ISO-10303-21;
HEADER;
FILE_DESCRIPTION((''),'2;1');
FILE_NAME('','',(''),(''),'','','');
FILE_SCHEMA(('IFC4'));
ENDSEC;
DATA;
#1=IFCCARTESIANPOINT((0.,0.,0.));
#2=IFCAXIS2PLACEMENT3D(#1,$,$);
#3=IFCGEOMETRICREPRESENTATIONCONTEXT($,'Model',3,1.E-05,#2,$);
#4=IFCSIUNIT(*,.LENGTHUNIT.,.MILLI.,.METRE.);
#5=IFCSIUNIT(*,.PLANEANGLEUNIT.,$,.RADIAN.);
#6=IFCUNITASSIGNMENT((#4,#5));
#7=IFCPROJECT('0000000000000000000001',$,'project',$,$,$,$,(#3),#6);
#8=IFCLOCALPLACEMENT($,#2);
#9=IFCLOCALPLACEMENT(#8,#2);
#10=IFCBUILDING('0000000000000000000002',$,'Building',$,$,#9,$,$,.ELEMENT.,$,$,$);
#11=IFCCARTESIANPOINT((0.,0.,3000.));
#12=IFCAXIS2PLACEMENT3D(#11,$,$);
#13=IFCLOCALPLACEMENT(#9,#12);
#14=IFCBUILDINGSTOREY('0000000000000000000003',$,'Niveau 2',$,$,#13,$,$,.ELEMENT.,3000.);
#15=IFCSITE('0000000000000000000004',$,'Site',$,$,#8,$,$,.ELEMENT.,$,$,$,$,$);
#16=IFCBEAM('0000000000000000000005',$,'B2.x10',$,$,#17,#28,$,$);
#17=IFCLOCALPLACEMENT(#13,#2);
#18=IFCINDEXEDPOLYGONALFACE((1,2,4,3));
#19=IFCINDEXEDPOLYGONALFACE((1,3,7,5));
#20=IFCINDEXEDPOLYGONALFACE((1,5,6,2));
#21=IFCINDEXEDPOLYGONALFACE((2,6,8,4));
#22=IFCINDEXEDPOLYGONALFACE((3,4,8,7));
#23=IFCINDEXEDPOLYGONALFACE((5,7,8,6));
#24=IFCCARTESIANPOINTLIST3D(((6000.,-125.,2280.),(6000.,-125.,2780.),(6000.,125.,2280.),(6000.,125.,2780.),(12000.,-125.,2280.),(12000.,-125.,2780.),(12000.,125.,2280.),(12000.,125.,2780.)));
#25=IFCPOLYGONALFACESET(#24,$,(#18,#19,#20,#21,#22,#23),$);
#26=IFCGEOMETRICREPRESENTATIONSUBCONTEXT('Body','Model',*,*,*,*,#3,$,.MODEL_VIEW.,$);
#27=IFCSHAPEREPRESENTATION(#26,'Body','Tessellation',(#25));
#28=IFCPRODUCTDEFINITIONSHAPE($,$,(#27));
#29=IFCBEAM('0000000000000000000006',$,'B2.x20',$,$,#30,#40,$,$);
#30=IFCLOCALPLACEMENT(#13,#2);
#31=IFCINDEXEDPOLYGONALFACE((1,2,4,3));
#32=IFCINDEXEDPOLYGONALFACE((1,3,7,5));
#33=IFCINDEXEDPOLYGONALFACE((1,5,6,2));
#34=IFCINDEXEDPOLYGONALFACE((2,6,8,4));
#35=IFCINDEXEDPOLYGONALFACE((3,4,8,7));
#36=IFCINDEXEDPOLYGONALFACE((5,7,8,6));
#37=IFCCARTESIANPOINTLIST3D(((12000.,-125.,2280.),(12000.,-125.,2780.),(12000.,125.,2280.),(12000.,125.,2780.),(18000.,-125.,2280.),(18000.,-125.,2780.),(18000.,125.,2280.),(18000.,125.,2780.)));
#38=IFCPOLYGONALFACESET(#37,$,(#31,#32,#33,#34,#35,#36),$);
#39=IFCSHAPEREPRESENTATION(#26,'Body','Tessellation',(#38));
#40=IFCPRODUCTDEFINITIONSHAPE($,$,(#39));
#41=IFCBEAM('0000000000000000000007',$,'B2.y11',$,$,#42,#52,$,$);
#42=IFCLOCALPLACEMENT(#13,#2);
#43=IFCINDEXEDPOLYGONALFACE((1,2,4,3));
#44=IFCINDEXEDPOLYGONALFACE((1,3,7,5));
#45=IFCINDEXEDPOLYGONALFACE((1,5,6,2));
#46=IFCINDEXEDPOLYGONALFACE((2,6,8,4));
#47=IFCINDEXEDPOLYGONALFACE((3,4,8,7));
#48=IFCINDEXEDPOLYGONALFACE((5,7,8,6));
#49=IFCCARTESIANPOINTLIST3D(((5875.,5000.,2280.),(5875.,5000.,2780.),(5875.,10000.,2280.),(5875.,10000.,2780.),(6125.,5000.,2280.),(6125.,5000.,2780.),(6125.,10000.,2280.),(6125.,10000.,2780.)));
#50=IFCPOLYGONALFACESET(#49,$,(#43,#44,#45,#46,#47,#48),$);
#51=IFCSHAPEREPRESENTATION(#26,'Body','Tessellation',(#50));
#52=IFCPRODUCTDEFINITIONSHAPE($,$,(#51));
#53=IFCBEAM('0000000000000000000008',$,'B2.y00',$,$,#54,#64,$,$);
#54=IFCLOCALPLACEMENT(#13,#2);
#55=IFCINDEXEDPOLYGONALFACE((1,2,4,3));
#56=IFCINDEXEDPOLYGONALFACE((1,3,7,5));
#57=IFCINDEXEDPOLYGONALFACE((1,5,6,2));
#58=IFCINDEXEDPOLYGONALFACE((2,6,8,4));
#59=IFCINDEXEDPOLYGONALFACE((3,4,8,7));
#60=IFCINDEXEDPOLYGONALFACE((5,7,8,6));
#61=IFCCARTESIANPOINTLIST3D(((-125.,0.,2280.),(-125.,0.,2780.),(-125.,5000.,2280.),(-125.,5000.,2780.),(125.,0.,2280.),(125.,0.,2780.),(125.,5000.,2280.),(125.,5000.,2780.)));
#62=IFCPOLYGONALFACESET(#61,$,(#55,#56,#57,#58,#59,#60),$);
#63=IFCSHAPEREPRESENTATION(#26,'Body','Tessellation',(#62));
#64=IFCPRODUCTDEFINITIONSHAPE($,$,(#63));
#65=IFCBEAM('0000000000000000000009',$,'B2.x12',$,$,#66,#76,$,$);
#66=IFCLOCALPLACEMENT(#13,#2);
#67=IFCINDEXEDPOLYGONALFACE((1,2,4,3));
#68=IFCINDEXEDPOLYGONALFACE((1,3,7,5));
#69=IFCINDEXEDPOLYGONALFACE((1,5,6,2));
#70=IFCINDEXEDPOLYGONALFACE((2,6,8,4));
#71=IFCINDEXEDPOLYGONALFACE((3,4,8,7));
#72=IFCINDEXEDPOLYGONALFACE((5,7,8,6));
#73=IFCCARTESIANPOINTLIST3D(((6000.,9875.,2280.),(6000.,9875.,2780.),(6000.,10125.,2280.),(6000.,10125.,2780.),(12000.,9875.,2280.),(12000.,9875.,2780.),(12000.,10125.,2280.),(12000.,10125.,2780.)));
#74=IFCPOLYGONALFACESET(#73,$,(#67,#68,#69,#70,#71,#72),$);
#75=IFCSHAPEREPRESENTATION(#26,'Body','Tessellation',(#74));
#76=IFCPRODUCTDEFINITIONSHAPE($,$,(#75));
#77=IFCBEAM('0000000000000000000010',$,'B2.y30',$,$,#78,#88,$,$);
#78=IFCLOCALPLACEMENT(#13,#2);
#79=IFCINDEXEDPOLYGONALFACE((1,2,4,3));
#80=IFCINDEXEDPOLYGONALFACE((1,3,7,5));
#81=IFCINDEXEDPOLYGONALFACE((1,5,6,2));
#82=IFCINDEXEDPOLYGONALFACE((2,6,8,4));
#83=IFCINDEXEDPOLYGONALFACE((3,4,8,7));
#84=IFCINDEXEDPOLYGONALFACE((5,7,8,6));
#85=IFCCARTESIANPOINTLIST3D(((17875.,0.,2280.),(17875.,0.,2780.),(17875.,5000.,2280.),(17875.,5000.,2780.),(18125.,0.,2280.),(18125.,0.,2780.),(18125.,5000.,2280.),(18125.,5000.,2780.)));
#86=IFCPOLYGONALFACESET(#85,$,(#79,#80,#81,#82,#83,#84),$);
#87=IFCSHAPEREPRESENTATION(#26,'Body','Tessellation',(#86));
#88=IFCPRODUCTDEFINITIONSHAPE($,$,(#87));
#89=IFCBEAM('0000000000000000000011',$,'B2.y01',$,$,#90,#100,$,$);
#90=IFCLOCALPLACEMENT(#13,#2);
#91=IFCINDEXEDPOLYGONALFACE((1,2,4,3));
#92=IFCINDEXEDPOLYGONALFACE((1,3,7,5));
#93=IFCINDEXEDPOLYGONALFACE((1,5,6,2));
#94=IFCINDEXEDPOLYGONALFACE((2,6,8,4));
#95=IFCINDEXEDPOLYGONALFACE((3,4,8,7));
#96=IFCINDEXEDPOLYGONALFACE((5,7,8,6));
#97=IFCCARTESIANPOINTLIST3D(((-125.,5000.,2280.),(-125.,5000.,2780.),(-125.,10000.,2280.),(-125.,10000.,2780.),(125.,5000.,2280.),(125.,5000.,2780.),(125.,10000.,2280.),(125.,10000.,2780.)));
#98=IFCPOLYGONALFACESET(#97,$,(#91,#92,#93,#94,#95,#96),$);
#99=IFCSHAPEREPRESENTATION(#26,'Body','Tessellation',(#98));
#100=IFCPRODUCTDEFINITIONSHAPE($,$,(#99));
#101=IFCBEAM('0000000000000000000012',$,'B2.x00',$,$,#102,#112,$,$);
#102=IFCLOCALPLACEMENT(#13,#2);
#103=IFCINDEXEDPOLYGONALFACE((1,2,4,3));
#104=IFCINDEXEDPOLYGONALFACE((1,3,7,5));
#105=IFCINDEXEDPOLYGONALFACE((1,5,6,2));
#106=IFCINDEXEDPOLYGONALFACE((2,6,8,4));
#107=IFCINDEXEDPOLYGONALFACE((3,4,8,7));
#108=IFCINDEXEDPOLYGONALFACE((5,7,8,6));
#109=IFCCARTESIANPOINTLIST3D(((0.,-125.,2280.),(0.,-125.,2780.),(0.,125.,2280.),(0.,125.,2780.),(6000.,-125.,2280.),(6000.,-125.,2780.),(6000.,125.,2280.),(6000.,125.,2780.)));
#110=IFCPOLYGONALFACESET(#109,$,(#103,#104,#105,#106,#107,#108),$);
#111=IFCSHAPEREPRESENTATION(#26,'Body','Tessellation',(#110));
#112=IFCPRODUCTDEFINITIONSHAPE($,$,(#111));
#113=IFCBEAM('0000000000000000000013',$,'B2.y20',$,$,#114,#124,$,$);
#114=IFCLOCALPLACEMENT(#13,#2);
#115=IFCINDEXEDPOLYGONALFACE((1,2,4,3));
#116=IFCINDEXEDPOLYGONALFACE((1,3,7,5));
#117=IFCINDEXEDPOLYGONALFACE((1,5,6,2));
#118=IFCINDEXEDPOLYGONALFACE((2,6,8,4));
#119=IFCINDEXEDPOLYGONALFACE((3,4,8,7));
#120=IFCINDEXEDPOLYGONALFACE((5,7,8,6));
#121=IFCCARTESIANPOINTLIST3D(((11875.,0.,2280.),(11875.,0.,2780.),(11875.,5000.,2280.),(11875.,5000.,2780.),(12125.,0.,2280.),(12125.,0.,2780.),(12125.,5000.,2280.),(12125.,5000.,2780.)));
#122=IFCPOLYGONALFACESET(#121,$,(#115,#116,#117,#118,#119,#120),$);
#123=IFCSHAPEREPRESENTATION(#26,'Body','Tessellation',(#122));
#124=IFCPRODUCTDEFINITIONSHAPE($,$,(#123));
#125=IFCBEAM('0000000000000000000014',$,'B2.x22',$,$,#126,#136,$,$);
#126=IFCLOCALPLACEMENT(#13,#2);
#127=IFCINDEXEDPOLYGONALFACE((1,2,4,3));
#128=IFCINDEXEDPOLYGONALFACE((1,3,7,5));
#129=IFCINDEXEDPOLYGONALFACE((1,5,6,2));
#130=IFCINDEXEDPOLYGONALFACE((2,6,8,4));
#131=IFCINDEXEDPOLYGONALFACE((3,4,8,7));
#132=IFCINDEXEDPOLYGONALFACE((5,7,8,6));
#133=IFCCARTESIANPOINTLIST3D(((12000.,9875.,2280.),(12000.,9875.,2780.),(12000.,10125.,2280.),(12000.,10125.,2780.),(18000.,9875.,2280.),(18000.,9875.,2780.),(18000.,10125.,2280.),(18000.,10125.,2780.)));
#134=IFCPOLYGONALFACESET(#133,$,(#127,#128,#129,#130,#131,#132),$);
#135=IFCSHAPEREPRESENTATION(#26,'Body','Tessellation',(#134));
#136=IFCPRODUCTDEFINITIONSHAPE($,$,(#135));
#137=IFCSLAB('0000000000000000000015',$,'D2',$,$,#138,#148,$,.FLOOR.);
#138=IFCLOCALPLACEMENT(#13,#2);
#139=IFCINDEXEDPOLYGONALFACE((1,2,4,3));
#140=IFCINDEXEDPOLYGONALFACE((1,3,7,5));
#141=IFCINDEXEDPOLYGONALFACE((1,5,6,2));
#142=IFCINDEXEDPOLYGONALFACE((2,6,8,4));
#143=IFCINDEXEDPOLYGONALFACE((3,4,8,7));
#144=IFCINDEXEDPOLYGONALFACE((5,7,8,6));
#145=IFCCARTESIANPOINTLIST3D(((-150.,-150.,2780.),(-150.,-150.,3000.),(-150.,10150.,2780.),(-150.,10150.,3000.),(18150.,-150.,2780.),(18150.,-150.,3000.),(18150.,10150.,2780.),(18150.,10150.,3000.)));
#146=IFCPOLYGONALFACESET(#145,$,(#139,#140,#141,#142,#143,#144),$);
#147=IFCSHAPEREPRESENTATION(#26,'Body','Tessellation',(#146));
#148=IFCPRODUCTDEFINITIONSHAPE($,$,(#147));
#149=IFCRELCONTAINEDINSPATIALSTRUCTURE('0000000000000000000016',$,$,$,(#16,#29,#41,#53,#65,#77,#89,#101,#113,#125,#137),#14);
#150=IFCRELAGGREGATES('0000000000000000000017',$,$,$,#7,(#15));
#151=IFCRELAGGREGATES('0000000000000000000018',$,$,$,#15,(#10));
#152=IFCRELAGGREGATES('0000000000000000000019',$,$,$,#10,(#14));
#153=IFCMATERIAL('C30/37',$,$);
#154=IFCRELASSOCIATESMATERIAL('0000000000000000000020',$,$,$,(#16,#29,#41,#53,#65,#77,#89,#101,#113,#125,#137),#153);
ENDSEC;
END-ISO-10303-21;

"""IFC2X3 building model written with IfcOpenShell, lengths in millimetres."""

from ifc_helpers import new_model, si_unit, frame, origin, origin_2d, place, context, subcontext, project, spatial, polyline, rectangle, outline, extrude, material, element, save


model = new_model("IFC2X3")

# Units and contexts
model_context = context("Model", 3, precision=1e-05, world=origin())
body_context = subcontext(model_context, "Body", "Model", "MODEL_VIEW")
ifc_project = project(units=[si_unit("LENGTHUNIT", "METRE", prefix="MILLI"), si_unit("PLANEANGLEUNIT", "RADIAN")], contexts=[model_context])

# Site, building, storey
site_placement = place(None, origin())
site = spatial("IfcSite", under=ifc_project, at=site_placement, Name="Site", CompositionType="ELEMENT")
building_placement = place(site_placement, origin())
building = spatial("IfcBuilding", under=site, at=building_placement, Name="Building", CompositionType="ELEMENT")
storey_placement = place(building_placement, frame((0.0, 0.0, 3000.0)))
storey = spatial("IfcBuildingStorey", under=building, at=storey_placement, Name="Niveau 2", CompositionType="ELEMENT", Elevation=3000.0)

# Shared definitions
ifc_material = material(Name="C30/37")

# Beams
for number, where, z_axis, x_axis, name in (
    (1, (6000.0, 0.0, 2530.0), (1.0, 0.0, 0.0), (0.0, 1.0, 0.0), "B2.x10"),
    (2, (12000.0, 0.0, 2530.0), (1.0, 0.0, 0.0), (0.0, 1.0, 0.0), "B2.x20"),
):
    element("IfcBeam", number, at=place(storey_placement, frame(where, z_axis=z_axis, x_axis=x_axis)), inside=storey, material=ifc_material, Name=name, context=body_context, shape_type="SweptSolid", body=[
        extrude(rectangle(XDim=250.0, YDim=500.0, at=origin_2d()), origin(), (0.0, 0.0, 1.0), 6000.0),
    ])
for number, where, z_axis, x_axis, name in (
    (3, (6000.0, 5000.0, 2530.0), (0.0, 1.0, 0.0), (-1.0, 0.0, 0.0), "B2.y11"),
    (4, (0.0, 0.0, 2530.0), (0.0, 1.0, 0.0), (-1.0, 0.0, 0.0), "B2.y00"),
):
    element("IfcBeam", number, at=place(storey_placement, frame(where, z_axis=z_axis, x_axis=x_axis)), inside=storey, material=ifc_material, Name=name, context=body_context, shape_type="SweptSolid", body=[
        extrude(rectangle(XDim=250.0, YDim=500.0, at=origin_2d()), origin(), (0.0, 0.0, 1.0), 5000.0),
    ])
beam_1_placement = place(storey_placement, frame((6000.0, 10000.0, 2530.0), z_axis=(1.0, 0.0, 0.0), x_axis=(0.0, 1.0, 0.0)))
element("IfcBeam", 5, at=beam_1_placement, inside=storey, material=ifc_material, Name="B2.x12", context=body_context, shape_type="SweptSolid", body=[
    extrude(rectangle(XDim=250.0, YDim=500.0, at=origin_2d()), origin(), (0.0, 0.0, 1.0), 6000.0),
])
for number, where, z_axis, x_axis, name in (
    (6, (18000.0, 0.0, 2530.0), (0.0, 1.0, 0.0), (-1.0, 0.0, 0.0), "B2.y30"),
    (7, (0.0, 5000.0, 2530.0), (0.0, 1.0, 0.0), (-1.0, 0.0, 0.0), "B2.y01"),
):
    element("IfcBeam", number, at=place(storey_placement, frame(where, z_axis=z_axis, x_axis=x_axis)), inside=storey, material=ifc_material, Name=name, context=body_context, shape_type="SweptSolid", body=[
        extrude(rectangle(XDim=250.0, YDim=500.0, at=origin_2d()), origin(), (0.0, 0.0, 1.0), 5000.0),
    ])
beam_2_placement = place(storey_placement, frame((0.0, 0.0, 2530.0), z_axis=(1.0, 0.0, 0.0), x_axis=(0.0, 1.0, 0.0)))
element("IfcBeam", 8, at=beam_2_placement, inside=storey, material=ifc_material, Name="B2.x00", context=body_context, shape_type="SweptSolid", body=[
    extrude(rectangle(XDim=250.0, YDim=500.0, at=origin_2d()), origin(), (0.0, 0.0, 1.0), 6000.0),
])
beam_3_placement = place(storey_placement, frame((12000.0, 0.0, 2530.0), z_axis=(0.0, 1.0, 0.0), x_axis=(-1.0, 0.0, 0.0)))
element("IfcBeam", 9, at=beam_3_placement, inside=storey, material=ifc_material, Name="B2.y20", context=body_context, shape_type="SweptSolid", body=[
    extrude(rectangle(XDim=250.0, YDim=500.0, at=origin_2d()), origin(), (0.0, 0.0, 1.0), 5000.0),
])
beam_4_placement = place(storey_placement, frame((12000.0, 10000.0, 2530.0), z_axis=(1.0, 0.0, 0.0), x_axis=(0.0, 1.0, 0.0)))
element("IfcBeam", 10, at=beam_4_placement, inside=storey, material=ifc_material, Name="B2.x22", context=body_context, shape_type="SweptSolid", body=[
    extrude(rectangle(XDim=250.0, YDim=500.0, at=origin_2d()), origin(), (0.0, 0.0, 1.0), 6000.0),
])

# Slab
slab_placement = place(storey_placement, frame((0.0, 0.0, 2780.0), z_axis=(0.0, 0.0, 1.0), x_axis=(1.0, 0.0, 0.0)))
element("IfcSlab", 11, at=slab_placement, inside=storey, material=ifc_material, Name="D2", PredefinedType="FLOOR", context=body_context, shape_type="SweptSolid", body=[
    extrude(outline(polyline([(-150.0, -150.0), (18150.0, -150.0), (18150.0, 10150.0), (-150.0, 10150.0), (-150.0, -150.0)])), origin(), (0.0, 0.0, 1.0), 220.0),
])

save(model, "model.ifc")
